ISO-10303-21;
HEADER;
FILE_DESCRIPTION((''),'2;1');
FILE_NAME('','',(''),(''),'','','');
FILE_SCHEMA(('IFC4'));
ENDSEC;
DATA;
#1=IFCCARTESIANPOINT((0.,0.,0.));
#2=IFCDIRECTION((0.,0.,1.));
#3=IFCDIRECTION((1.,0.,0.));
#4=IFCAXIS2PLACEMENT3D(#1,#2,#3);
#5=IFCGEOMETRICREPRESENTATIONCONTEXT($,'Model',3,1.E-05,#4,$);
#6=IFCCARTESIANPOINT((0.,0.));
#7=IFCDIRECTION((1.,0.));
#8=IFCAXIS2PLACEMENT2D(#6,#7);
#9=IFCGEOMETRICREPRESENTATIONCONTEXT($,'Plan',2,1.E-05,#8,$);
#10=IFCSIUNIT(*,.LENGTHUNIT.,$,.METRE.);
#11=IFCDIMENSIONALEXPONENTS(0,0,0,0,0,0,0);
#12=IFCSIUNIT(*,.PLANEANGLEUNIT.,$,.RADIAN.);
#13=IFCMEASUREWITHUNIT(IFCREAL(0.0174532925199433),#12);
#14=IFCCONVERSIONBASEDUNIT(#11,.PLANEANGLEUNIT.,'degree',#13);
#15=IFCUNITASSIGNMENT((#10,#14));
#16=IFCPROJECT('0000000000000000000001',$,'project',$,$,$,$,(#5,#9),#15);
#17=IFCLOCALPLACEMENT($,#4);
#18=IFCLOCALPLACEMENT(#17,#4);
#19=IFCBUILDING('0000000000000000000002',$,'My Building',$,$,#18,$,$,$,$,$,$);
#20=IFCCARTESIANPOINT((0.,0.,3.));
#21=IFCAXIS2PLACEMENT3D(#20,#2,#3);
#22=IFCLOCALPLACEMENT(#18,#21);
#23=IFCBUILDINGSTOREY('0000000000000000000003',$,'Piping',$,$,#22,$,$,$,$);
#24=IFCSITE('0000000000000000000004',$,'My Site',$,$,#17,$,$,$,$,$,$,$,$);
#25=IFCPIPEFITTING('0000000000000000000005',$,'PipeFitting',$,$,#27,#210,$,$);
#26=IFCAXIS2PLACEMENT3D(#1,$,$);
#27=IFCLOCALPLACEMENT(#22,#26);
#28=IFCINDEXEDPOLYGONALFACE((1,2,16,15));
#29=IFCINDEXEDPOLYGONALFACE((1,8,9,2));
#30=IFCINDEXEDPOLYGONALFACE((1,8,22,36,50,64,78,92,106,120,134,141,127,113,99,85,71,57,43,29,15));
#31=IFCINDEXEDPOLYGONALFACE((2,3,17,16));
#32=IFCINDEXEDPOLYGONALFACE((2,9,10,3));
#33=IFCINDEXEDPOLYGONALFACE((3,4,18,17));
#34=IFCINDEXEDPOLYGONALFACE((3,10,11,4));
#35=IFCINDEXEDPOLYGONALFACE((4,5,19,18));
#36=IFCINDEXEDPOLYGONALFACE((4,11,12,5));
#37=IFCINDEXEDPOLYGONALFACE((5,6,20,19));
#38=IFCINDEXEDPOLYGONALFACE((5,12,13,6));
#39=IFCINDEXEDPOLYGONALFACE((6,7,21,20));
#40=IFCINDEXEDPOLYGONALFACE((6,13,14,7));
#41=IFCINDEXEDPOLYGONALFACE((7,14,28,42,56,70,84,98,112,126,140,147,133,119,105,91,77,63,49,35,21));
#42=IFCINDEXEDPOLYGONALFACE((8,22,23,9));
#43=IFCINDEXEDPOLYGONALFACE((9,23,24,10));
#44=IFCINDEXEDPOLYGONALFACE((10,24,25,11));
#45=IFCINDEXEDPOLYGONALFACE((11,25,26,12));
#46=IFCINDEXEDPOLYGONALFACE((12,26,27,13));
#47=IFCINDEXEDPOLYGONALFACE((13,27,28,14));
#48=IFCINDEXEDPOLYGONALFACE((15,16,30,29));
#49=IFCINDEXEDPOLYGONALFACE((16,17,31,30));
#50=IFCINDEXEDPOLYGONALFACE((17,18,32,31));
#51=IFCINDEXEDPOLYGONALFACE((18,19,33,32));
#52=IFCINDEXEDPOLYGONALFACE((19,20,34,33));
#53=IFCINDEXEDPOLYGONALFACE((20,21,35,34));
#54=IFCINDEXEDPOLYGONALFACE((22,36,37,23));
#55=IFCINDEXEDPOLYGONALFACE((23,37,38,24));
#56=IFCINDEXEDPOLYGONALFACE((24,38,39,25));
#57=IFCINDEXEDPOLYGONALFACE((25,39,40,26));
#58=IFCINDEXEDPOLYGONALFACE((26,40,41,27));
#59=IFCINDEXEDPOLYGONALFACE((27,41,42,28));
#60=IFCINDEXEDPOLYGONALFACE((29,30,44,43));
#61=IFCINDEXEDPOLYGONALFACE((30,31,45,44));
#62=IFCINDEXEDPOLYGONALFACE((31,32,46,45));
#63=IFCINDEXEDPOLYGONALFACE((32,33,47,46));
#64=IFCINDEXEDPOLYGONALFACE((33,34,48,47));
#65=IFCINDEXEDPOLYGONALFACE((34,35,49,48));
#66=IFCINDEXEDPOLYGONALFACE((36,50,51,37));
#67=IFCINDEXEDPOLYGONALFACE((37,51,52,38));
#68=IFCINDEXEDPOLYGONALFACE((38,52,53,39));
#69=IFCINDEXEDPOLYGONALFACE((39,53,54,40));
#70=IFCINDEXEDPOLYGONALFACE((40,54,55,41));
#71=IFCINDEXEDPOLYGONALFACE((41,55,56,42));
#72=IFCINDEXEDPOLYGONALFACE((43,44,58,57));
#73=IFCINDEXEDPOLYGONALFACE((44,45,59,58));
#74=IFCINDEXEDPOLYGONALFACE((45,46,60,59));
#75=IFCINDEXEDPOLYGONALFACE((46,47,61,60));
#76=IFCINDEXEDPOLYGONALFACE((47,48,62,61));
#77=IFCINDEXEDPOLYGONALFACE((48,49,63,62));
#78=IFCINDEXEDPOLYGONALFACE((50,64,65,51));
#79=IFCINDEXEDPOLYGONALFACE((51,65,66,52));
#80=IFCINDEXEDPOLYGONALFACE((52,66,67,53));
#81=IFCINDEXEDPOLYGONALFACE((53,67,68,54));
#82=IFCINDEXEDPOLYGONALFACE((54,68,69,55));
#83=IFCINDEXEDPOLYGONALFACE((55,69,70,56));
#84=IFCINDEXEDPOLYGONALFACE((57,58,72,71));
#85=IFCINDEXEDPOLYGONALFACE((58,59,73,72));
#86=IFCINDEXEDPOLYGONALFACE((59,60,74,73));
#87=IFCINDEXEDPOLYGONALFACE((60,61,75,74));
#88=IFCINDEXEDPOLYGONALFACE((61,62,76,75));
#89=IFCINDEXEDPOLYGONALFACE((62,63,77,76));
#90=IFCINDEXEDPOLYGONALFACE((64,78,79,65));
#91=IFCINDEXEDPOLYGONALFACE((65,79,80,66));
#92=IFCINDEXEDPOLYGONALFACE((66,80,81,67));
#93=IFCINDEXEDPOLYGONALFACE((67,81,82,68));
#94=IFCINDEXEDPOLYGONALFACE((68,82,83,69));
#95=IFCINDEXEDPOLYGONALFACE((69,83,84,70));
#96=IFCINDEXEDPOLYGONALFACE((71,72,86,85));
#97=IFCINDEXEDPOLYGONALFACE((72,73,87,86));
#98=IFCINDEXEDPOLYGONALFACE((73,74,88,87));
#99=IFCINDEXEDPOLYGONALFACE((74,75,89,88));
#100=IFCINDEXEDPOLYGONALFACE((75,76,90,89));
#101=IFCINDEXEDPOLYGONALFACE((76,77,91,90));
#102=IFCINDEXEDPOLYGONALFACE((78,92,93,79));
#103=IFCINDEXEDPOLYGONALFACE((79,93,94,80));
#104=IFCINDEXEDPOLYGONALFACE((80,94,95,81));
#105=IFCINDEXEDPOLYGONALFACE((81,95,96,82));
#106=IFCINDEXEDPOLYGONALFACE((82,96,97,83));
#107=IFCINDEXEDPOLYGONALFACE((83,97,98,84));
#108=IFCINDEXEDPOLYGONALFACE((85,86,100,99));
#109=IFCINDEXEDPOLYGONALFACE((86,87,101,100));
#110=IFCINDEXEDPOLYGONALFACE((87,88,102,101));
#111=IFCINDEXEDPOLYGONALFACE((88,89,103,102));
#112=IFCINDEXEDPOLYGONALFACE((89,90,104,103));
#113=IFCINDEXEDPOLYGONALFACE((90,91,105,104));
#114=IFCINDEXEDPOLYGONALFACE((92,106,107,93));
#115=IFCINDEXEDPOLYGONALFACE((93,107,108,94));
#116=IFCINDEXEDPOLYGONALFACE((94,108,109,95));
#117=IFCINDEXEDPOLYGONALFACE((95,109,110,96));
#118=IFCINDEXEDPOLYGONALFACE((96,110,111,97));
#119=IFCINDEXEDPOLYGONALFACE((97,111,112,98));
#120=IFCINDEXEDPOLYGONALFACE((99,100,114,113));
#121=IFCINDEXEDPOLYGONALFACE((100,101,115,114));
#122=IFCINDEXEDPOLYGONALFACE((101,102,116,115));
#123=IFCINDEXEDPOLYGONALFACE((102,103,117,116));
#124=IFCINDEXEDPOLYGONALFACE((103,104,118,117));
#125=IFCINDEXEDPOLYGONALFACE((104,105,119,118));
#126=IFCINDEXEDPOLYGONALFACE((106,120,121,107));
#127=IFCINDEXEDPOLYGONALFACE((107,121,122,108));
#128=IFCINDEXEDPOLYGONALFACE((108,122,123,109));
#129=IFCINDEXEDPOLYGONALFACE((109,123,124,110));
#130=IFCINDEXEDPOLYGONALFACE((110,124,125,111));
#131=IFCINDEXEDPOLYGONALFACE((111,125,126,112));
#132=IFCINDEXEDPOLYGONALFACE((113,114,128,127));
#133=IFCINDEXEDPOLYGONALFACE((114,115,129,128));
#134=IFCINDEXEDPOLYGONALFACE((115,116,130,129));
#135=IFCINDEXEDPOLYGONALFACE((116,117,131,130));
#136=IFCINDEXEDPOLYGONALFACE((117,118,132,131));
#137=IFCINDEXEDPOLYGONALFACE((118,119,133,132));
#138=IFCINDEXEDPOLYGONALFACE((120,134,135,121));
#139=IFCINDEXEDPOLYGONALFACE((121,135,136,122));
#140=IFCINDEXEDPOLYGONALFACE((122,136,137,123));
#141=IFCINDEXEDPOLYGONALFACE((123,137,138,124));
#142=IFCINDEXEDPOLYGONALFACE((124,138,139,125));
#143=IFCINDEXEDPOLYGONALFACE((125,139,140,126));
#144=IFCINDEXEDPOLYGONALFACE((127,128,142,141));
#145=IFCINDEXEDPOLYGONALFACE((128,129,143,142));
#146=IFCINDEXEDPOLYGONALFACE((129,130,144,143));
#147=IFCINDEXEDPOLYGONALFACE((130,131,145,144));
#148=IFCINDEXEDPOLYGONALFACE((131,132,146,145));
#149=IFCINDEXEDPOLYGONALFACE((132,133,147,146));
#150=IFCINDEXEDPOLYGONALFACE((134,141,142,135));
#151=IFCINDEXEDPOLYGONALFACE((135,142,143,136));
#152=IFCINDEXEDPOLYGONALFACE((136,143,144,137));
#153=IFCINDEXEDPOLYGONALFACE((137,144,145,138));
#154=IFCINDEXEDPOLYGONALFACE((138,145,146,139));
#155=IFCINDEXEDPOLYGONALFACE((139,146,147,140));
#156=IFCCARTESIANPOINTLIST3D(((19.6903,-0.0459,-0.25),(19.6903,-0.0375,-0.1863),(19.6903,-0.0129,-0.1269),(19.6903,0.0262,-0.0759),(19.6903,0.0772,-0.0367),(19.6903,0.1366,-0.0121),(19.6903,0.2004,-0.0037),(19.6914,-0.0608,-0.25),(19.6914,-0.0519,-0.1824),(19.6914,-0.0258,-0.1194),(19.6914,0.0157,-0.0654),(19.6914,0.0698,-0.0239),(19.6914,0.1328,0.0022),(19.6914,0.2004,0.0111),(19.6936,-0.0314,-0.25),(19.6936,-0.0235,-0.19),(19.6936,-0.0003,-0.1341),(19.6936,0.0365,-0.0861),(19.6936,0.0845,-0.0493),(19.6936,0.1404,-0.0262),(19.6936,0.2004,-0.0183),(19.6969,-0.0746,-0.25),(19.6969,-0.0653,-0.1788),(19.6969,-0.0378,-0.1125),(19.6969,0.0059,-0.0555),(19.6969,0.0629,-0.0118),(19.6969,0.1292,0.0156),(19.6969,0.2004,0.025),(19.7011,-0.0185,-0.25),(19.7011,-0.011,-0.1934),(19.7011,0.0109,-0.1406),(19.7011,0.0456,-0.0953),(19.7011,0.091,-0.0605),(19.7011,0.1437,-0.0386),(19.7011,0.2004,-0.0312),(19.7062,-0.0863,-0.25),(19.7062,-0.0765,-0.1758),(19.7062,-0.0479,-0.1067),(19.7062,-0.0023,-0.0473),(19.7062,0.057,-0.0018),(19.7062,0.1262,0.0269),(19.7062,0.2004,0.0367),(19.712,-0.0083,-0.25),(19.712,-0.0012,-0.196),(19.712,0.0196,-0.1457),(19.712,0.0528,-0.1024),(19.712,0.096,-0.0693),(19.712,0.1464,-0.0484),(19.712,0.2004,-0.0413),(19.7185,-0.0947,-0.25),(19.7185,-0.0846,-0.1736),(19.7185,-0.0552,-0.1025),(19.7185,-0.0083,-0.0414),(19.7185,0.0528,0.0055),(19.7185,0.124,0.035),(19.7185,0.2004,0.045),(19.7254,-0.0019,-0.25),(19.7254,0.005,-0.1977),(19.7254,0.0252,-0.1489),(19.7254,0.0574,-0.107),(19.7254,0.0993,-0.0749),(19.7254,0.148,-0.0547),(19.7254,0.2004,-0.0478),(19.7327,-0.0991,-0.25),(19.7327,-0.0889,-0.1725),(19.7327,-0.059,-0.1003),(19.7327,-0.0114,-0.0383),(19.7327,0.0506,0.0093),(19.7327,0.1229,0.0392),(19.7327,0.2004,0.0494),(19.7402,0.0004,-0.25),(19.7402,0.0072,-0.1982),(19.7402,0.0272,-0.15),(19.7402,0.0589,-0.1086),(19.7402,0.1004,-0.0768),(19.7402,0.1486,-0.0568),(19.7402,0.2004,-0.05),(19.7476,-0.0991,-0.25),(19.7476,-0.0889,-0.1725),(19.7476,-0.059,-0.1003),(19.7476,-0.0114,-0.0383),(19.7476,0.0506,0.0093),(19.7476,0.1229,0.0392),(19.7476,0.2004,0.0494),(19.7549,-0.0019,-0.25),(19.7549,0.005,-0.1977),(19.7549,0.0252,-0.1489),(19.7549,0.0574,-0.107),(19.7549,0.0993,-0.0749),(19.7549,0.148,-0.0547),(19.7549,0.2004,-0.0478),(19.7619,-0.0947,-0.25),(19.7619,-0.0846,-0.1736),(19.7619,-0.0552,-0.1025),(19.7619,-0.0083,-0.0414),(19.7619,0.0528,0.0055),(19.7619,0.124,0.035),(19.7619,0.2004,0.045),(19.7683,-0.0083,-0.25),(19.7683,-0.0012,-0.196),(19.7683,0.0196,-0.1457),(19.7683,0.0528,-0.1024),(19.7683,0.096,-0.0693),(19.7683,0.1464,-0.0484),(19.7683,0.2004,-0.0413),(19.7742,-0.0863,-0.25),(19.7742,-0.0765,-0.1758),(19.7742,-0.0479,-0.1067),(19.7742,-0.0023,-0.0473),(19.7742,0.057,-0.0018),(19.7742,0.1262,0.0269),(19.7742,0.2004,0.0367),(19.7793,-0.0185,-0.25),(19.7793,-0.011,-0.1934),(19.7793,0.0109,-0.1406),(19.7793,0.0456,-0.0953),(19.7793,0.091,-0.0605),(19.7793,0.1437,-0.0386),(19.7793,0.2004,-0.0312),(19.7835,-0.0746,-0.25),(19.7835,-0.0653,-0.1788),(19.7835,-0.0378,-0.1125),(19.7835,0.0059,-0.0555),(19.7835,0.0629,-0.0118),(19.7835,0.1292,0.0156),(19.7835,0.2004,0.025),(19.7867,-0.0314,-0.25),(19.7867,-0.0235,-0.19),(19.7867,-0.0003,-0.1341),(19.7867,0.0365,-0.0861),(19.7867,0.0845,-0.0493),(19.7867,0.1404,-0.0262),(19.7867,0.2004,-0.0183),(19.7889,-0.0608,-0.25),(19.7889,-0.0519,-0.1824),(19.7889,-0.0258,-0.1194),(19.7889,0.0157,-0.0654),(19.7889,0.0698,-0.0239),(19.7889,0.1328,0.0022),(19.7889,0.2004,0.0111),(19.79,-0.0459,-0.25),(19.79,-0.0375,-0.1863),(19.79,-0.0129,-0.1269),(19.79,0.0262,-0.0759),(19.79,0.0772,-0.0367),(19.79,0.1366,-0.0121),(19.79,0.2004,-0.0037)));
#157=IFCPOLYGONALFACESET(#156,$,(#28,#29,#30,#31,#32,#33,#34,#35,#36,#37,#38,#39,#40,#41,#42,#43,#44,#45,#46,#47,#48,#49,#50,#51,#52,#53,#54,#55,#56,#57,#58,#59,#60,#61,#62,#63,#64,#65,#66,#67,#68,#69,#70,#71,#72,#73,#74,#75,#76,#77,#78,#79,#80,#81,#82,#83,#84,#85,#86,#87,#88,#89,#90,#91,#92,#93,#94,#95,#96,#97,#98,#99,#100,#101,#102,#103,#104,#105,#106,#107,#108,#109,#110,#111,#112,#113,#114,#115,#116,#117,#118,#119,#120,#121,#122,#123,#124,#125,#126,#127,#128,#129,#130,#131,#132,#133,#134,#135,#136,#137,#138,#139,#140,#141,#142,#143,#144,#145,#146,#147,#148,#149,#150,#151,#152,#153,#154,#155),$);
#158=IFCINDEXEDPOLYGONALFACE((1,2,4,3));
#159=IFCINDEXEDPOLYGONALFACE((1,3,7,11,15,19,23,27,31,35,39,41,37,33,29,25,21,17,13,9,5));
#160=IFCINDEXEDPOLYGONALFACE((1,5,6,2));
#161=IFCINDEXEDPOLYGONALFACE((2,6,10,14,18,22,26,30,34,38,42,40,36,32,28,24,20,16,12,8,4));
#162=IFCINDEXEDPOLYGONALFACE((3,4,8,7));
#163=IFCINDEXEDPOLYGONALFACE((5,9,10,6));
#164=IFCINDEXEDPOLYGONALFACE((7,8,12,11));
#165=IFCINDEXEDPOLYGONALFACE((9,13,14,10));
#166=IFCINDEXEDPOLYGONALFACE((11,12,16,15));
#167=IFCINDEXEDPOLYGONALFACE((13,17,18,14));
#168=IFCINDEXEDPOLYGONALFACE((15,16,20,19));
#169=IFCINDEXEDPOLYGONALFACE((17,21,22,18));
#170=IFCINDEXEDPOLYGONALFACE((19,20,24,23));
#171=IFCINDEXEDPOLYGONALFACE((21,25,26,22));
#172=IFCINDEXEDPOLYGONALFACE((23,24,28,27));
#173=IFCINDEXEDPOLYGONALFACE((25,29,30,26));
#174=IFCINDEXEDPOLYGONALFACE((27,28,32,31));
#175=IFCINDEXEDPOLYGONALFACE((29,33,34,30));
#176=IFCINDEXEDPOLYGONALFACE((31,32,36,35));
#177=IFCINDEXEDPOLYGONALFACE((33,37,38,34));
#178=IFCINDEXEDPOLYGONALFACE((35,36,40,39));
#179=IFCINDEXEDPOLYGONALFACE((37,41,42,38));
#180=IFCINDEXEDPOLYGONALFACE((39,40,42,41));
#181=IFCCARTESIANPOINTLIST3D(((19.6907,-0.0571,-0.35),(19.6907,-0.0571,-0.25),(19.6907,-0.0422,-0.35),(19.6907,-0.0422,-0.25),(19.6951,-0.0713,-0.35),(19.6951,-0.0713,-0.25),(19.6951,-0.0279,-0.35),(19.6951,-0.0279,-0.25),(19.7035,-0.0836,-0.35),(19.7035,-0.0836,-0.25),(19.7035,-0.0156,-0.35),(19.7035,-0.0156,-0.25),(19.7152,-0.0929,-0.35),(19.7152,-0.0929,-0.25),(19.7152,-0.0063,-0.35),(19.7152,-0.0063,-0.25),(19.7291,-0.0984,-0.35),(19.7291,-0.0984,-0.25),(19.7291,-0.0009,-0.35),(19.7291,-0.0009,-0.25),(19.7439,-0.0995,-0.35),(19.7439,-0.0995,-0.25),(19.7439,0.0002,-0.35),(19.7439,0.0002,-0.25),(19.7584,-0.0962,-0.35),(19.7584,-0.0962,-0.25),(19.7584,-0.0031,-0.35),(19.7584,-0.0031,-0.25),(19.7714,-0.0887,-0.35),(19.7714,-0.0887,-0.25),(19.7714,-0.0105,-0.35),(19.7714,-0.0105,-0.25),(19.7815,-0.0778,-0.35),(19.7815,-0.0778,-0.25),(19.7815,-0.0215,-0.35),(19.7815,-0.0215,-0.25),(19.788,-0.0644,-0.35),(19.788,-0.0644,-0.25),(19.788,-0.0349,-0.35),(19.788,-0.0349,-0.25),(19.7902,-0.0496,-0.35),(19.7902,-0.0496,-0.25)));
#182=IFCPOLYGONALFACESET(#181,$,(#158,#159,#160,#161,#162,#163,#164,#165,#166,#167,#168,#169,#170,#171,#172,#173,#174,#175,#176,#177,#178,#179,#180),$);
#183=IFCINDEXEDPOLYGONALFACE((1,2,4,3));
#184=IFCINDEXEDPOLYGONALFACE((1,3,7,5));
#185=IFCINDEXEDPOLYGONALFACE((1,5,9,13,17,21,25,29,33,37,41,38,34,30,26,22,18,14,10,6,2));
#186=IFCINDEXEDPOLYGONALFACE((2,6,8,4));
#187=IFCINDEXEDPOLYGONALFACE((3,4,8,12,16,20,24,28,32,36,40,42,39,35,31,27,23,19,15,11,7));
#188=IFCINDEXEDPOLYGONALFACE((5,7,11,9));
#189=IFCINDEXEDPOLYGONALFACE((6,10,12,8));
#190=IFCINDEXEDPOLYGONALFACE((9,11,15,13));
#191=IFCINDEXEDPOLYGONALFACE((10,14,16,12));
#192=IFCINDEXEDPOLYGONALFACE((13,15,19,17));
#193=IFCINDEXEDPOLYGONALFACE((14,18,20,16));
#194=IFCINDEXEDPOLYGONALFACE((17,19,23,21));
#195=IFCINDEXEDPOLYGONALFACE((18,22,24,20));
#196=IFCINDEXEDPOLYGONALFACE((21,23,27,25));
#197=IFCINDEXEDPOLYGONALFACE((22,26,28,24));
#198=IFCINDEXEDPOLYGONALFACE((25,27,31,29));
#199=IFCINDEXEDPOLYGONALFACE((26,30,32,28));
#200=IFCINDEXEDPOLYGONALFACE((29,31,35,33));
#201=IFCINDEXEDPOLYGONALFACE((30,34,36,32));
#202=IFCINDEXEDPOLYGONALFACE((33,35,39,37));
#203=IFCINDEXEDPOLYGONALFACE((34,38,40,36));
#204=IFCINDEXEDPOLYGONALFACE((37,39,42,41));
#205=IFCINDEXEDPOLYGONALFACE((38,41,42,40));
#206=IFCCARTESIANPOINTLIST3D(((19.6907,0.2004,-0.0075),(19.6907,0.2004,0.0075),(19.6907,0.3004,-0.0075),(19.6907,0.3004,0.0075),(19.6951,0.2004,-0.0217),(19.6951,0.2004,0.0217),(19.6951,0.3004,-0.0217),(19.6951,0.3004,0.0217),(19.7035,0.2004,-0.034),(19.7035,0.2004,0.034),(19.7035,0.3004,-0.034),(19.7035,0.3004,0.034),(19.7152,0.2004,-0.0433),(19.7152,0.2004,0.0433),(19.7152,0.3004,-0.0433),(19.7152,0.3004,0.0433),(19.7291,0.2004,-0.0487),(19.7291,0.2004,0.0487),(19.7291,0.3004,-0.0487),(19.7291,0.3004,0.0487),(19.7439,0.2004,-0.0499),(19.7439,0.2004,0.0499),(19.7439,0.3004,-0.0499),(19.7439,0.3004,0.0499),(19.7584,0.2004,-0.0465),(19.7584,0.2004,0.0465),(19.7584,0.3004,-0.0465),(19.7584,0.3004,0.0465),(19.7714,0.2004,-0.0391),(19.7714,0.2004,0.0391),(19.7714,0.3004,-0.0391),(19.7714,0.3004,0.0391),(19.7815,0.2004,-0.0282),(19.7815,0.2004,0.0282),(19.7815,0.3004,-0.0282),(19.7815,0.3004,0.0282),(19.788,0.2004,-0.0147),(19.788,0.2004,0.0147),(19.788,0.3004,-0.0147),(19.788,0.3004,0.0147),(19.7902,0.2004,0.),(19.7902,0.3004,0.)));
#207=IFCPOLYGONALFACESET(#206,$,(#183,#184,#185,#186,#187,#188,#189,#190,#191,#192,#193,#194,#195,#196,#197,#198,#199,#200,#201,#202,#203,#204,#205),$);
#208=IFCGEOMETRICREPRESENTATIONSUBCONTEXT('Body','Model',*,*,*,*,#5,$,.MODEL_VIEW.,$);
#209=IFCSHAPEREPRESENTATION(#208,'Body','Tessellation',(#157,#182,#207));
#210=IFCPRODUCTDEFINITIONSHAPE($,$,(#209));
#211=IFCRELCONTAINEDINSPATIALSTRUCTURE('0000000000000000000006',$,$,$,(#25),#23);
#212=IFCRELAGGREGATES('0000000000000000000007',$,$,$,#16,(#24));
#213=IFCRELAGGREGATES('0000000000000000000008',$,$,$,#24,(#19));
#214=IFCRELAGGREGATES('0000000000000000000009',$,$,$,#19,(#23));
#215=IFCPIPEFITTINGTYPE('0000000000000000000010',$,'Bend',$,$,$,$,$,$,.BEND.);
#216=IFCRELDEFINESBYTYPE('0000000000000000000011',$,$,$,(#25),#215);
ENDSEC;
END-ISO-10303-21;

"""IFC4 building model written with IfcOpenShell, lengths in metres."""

from ifc_helpers import new_model, entity, si_unit, converted_unit, frame, origin_with_axes, origin_2d_with_axis, place, context, subcontext, project, spatial, circle, extrude, source, transform, mapped, type_object, type_shapes, element, save


model = new_model("IFC4")

# Units and contexts
model_context = context("Model", 3, precision=1e-05, world=origin_with_axes())
plan_context = context("Plan", 2, precision=1e-05, world=origin_2d_with_axis())
body_context = subcontext(model_context, "Body", "Model", "MODEL_VIEW")
ifc_project = project(units=[si_unit("LENGTHUNIT", "METRE"), converted_unit("PLANEANGLEUNIT", "degree", entity("IfcReal", 0.0174532925199433), si_unit("PLANEANGLEUNIT", "RADIAN"), dimensions=[0, 0, 0, 0, 0, 0, 0])], contexts=[model_context, plan_context])

# Site, building, storey
site_placement = place(None, origin_with_axes())
site = spatial("IfcSite", under=ifc_project, at=site_placement, Name="My Site")
building_placement = place(site_placement, origin_with_axes())
building = spatial("IfcBuilding", under=site, at=building_placement, Name="My Building")
storey_placement = place(building_placement, frame((0.0, 0.0, 3.0), z_axis=(0.0, 0.0, 1.0), x_axis=(1.0, 0.0, 0.0)))
storey = spatial("IfcBuildingStorey", under=building, at=storey_placement, Name="Piping")

# Pipe fitting
pipe_fitting_type = type_object("IfcPipeFittingType", Name="Bend", PredefinedType="BEND")
shared_shape = source(origin_with_axes(), body_context, "Body", "SolidModel", [
    entity("IfcSweptDiskSolid", entity("IfcIndexedPolyCurve", entity("IfcCartesianPointList3D", [[0.0, 0.0, -0.1], [0.0, -0.0732, -0.2768], [0.0, -0.25, -0.35]]), [entity("IfcArcIndex", [1, 2, 3])]), 0.05),
    extrude(circle(Radius=0.05), origin_with_axes(), (0.0, 0.0, -1.0), 0.1),
    extrude(circle(Radius=0.05), frame((0.0, -0.25, -0.35), z_axis=(0.0, -1.0, 0.0), x_axis=(1.0, 0.0, 0.0)), (0.0, 0.0, 1.0), 0.1),
])
type_shapes(pipe_fitting_type, [shared_shape])
for number, where, z_axis, x_axis, name in (
    (1, (19.7402, -0.0496, -0.35), (0.0, 0.0, -1.0), (1.0, 0.0, 0.0), "PipeFitting"),
):
    element("IfcPipeFitting", number, at=place(storey_placement, frame(where, z_axis=z_axis, x_axis=x_axis)), inside=storey, type_object=pipe_fitting_type, Name=name, context=body_context, shape_type="MappedRepresentation", body=[
        mapped(shared_shape, transform((0.0, 0.0, 0.0), x_axis=(1.0, 0.0, 0.0), y_axis=(0.0, 1.0, 0.0), z_axis=(0.0, 0.0, 1.0), scale=1.0)),
    ])

save(model, "model.ifc")
